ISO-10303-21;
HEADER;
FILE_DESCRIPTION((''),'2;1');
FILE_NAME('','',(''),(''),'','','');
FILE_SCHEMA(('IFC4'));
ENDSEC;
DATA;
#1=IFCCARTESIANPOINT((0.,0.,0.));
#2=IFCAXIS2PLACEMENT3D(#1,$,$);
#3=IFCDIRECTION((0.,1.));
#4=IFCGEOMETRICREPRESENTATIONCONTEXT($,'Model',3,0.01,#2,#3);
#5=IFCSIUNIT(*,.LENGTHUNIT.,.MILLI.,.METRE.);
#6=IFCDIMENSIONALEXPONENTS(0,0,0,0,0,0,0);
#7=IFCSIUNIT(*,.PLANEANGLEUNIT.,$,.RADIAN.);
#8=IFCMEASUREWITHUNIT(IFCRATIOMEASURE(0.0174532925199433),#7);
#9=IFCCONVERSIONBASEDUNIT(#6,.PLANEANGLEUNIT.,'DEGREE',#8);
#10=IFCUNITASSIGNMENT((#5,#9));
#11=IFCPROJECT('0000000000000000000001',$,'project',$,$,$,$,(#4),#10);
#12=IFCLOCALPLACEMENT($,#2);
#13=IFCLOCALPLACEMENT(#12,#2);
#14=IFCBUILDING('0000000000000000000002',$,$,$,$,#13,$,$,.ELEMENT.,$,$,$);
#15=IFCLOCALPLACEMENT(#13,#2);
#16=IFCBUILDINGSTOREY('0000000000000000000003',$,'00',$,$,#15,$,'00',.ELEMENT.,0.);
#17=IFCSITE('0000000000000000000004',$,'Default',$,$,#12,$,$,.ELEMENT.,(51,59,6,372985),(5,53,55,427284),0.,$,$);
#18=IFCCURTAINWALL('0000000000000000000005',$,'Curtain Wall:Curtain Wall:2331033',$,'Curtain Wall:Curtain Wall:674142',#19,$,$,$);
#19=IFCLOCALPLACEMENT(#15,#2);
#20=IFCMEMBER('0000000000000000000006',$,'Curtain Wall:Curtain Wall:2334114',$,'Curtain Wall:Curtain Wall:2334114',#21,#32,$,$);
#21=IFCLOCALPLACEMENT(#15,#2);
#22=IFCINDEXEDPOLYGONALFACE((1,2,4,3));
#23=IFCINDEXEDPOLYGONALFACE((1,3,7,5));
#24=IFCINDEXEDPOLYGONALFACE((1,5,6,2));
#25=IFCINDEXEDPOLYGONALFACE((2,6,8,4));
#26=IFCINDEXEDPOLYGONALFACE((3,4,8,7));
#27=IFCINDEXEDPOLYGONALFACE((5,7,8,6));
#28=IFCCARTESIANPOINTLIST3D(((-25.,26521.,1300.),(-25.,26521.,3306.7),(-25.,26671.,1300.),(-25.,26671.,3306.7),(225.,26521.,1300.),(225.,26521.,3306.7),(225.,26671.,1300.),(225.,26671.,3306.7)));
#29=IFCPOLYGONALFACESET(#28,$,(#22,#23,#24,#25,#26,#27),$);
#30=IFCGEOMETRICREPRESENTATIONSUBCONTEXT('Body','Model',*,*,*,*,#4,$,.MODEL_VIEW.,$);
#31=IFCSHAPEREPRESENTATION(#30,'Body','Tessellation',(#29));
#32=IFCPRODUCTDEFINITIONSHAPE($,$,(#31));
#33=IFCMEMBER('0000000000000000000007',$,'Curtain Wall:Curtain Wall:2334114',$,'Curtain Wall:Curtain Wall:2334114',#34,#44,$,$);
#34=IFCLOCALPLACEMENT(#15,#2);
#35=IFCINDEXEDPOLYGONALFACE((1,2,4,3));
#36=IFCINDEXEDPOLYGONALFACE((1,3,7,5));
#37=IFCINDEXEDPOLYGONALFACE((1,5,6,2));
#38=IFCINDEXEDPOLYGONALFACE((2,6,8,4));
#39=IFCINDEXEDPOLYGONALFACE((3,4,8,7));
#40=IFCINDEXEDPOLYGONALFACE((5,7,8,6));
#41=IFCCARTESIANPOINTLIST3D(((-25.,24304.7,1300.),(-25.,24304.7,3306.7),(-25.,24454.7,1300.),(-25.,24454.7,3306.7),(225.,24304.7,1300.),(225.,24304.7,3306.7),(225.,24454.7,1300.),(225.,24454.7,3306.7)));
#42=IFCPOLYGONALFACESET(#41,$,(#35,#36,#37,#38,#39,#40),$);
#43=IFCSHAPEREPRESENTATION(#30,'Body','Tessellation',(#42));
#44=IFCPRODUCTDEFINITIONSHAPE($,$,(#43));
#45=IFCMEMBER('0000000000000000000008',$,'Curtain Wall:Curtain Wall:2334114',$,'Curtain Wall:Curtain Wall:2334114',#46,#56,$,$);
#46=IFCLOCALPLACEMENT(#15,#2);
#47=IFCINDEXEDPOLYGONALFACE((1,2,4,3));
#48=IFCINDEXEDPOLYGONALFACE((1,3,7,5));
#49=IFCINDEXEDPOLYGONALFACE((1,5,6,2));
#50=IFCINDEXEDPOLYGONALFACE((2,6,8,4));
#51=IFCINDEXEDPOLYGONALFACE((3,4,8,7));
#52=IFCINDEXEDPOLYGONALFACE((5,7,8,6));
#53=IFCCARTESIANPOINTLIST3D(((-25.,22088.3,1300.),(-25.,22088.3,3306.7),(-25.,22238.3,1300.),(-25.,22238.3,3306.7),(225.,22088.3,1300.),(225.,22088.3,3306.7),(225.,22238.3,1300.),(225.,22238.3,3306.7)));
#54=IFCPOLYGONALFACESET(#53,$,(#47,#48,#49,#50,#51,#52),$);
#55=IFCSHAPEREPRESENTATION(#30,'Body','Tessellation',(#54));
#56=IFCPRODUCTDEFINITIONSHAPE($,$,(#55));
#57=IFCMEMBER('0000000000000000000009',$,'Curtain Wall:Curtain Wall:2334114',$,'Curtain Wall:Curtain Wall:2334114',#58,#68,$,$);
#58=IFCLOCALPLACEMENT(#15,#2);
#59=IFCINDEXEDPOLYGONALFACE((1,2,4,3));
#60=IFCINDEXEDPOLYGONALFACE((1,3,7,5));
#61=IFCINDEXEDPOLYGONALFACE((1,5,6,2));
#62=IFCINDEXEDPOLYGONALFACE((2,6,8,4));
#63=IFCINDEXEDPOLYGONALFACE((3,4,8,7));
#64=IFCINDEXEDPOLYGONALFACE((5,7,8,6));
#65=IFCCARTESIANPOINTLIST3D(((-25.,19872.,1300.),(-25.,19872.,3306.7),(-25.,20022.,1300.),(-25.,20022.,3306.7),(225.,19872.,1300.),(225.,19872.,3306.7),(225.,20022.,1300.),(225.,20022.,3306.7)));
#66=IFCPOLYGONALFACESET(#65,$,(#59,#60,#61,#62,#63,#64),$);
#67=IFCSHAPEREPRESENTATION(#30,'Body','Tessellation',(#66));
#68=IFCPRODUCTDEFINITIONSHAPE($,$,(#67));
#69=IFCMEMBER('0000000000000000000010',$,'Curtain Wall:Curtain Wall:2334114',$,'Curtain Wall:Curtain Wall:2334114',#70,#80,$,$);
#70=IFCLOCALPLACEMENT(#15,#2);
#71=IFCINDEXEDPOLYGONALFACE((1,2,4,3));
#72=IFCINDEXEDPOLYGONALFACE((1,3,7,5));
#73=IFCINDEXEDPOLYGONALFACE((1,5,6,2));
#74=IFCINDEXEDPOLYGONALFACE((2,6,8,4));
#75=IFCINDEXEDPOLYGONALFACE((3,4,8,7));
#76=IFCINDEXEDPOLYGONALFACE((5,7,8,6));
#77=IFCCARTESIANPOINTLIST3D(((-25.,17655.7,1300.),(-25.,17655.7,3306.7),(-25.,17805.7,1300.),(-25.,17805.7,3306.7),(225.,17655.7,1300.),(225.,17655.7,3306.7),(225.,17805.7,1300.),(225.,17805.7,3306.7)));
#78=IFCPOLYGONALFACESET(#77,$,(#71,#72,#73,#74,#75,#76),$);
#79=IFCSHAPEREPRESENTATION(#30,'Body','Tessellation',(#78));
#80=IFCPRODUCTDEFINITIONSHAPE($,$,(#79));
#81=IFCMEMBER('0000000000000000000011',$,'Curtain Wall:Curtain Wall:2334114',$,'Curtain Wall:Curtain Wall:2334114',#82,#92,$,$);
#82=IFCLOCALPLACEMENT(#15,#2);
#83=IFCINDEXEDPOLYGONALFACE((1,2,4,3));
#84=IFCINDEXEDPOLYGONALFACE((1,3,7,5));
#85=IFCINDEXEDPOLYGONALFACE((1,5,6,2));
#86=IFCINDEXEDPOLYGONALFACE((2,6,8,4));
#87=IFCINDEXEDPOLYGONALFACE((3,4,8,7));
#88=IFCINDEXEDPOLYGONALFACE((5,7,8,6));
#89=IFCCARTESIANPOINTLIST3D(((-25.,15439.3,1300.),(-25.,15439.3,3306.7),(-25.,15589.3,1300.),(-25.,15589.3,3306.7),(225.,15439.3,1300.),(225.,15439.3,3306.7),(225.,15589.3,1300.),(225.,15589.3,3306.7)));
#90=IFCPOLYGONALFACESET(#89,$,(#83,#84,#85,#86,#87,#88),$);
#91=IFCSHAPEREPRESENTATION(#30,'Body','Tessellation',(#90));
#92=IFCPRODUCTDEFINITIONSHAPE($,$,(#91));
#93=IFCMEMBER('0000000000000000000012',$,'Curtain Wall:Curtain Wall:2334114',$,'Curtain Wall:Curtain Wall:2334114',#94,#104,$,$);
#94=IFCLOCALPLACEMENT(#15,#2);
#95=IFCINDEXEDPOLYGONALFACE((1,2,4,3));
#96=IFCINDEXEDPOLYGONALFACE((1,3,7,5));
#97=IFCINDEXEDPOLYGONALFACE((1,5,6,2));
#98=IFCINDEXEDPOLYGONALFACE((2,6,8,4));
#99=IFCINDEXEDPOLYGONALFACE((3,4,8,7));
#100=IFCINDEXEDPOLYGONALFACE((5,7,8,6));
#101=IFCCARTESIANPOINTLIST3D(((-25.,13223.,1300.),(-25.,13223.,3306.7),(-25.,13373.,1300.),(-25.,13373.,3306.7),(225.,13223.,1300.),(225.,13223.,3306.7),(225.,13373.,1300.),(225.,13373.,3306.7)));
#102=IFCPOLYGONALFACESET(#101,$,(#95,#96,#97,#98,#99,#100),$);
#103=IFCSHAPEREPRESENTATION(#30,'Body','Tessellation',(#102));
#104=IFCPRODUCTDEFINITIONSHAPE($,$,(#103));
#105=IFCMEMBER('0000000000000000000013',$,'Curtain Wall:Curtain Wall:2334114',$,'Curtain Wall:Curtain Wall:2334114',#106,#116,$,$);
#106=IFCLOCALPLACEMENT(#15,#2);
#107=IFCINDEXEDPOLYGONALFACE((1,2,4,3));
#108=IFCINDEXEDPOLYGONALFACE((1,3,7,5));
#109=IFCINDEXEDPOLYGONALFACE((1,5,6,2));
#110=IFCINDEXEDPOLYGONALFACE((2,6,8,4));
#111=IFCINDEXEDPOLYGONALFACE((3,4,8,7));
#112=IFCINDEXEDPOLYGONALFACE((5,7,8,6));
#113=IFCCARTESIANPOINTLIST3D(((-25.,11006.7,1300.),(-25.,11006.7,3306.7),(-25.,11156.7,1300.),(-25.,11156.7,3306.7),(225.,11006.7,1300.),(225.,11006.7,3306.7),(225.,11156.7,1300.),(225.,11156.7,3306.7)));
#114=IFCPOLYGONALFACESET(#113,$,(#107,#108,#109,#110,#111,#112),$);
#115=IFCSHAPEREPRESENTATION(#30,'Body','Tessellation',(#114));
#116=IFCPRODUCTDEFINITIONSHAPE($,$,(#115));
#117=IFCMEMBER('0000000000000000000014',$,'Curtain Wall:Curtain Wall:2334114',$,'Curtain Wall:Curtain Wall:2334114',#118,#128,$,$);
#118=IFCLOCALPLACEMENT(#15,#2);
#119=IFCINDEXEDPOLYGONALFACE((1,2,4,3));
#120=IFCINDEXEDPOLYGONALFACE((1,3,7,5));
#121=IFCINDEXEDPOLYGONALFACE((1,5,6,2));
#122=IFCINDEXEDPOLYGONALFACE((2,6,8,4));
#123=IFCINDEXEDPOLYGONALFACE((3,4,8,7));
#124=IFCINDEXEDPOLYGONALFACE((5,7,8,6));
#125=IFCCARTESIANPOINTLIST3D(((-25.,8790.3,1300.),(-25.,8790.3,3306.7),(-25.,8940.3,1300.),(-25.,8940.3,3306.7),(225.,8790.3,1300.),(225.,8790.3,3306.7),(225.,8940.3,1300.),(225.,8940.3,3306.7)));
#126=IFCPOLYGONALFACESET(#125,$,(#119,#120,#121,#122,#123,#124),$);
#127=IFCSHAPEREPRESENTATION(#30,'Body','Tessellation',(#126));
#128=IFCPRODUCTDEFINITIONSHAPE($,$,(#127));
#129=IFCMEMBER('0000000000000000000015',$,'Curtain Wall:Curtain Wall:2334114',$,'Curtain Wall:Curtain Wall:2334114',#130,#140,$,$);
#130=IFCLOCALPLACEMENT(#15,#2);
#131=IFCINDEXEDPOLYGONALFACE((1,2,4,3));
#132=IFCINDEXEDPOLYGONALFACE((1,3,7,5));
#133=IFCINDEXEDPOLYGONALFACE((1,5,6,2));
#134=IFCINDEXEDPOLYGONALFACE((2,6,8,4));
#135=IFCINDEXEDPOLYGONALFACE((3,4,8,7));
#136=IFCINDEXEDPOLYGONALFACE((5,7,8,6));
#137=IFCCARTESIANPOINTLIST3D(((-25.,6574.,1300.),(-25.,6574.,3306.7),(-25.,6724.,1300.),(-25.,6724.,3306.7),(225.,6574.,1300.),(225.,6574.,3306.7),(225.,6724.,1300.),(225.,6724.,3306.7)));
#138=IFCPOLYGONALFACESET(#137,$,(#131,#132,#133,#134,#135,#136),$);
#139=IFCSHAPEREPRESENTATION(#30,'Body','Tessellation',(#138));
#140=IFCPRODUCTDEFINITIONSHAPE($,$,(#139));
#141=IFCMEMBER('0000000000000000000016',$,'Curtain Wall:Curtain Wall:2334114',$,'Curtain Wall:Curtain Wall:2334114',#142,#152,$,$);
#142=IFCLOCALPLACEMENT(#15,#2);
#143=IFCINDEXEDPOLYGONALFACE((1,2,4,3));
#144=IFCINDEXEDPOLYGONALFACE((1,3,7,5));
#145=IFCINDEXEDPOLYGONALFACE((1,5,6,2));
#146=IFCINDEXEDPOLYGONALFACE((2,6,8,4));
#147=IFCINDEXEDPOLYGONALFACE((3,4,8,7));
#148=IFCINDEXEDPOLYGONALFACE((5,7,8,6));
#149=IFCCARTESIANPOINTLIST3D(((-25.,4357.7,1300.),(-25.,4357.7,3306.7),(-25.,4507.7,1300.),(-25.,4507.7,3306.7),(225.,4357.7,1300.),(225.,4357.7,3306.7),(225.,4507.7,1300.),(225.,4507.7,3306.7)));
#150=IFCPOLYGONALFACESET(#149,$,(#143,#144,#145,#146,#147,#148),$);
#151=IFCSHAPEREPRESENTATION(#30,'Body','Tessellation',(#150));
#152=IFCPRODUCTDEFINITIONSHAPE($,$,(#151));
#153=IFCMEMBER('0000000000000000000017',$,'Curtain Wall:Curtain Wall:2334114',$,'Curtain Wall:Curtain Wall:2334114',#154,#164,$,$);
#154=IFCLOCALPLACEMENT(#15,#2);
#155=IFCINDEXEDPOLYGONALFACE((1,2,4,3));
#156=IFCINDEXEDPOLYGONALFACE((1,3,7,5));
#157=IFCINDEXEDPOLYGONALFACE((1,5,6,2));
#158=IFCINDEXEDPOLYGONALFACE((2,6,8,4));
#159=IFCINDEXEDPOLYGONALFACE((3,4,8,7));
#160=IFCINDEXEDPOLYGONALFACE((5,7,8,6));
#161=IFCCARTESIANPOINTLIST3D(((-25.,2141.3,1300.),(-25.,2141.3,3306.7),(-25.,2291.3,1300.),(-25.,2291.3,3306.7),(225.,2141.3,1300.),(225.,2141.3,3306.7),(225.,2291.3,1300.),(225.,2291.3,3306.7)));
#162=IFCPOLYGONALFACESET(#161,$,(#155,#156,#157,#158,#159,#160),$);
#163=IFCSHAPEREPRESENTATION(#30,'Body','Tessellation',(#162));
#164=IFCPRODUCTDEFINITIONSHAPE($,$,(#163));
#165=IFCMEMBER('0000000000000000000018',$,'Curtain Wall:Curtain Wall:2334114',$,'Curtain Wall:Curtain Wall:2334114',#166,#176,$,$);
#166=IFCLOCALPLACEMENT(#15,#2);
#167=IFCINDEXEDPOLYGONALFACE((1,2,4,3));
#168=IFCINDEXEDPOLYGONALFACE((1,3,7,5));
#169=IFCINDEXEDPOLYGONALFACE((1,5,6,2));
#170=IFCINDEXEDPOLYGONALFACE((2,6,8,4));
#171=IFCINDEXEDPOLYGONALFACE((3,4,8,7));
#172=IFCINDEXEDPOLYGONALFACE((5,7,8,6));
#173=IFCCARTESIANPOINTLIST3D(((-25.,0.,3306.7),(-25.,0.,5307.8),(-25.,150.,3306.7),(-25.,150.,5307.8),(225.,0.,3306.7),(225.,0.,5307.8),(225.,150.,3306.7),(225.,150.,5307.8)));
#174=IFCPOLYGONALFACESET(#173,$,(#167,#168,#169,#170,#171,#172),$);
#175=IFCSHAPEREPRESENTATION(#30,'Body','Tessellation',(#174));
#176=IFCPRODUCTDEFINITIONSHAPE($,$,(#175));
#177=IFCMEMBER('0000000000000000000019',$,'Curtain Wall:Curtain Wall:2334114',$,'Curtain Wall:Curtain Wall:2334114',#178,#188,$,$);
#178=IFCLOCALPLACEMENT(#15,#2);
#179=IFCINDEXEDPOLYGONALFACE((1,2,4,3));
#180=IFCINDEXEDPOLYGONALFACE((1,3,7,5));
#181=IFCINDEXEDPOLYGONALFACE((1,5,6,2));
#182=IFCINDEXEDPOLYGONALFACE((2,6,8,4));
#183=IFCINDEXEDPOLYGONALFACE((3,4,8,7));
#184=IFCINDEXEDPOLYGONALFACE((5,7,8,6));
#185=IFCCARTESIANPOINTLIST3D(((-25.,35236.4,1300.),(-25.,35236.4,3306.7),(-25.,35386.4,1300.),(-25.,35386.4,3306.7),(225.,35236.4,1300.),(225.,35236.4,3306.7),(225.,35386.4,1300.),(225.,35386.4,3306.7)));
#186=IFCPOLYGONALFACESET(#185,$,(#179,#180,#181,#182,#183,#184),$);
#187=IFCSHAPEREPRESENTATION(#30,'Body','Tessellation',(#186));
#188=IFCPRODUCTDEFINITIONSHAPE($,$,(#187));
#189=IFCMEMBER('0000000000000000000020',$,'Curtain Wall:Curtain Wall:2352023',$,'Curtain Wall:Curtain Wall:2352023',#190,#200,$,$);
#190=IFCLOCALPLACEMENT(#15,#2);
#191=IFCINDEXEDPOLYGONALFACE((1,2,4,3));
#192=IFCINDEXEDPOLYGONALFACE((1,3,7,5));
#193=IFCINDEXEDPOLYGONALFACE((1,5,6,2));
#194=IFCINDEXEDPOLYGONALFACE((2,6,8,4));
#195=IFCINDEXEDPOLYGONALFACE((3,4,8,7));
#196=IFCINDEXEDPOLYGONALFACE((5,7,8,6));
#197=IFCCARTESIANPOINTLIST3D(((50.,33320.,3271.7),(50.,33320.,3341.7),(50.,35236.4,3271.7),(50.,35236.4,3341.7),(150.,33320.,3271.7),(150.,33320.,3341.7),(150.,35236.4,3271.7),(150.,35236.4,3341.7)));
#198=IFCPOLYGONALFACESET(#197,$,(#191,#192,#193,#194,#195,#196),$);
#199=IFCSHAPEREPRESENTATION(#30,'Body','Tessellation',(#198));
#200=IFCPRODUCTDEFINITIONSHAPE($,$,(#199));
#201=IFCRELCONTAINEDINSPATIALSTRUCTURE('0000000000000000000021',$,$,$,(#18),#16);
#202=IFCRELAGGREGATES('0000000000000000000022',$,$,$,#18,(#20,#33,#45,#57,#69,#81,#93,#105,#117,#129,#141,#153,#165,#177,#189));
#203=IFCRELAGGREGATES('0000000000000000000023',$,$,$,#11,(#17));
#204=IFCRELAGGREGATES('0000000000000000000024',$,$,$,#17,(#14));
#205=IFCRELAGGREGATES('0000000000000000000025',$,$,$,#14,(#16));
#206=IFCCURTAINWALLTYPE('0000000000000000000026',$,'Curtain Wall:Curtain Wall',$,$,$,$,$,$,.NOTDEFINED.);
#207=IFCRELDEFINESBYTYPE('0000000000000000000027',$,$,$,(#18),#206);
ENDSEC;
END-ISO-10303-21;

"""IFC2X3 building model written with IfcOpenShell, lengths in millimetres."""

from ifc_helpers import new_model, entity, si_unit, converted_unit, direction, frame, frame_2d, origin, origin_2d_with_axis, place, context, subcontext, project, spatial, rectangle, extrude, type_object, element, aggregate, save


model = new_model("IFC2X3")

# Units and contexts
model_context = context("Model", 3, precision=0.01, world=origin(), true_north=direction((0.0, 1.0)))
body_context = subcontext(model_context, "Body", "Model", "MODEL_VIEW")
ifc_project = project(units=[si_unit("LENGTHUNIT", "METRE", prefix="MILLI"), converted_unit("PLANEANGLEUNIT", "DEGREE", entity("IfcRatioMeasure", 0.0174532925199433), si_unit("PLANEANGLEUNIT", "RADIAN"), dimensions=[0, 0, 0, 0, 0, 0, 0])], contexts=[model_context])

# Site, building, storey
site_placement = place(None, origin())
site = spatial("IfcSite", under=ifc_project, at=site_placement, Name="Default", CompositionType="ELEMENT", RefLatitude=(51, 59, 6, 372985), RefLongitude=(5, 53, 55, 427284), RefElevation=0.0)
building_placement = place(site_placement, origin())
building = spatial("IfcBuilding", under=site, at=building_placement, CompositionType="ELEMENT")
storey_placement = place(building_placement, origin())
storey = spatial("IfcBuildingStorey", under=building, at=storey_placement, Name="00", LongName="00", CompositionType="ELEMENT", Elevation=0.0)

# Curtain wall, members
curtain_wall_type = type_object("IfcCurtainWallType", Name="Curtain Wall:Curtain Wall", PredefinedType="NOTDEFINED")
curtain_wall_placement = place(storey_placement, origin())
curtain_wall = element("IfcCurtainWall", 1, at=curtain_wall_placement, inside=storey, type_object=curtain_wall_type, Name="Curtain Wall:Curtain Wall:2331033", ObjectType="Curtain Wall:Curtain Wall:674142")
member_1_placement = place(curtain_wall_placement, origin())
member_1 = element("IfcMember", 2, at=member_1_placement, Name="Curtain Wall:Curtain Wall:2334114", ObjectType="Curtain Wall:Curtain Wall:2334114", context=body_context, shape_type="SweptSolid", body=[
    extrude(rectangle(XDim=250.0, YDim=150.0, at=frame_2d((0.0, 0.0), x_axis=(1.0, 0.0))), frame((100.0, 26596.0, 1300.0), z_axis=(0.0, 0.0, 1.0), x_axis=(-1.0, 0.0, 0.0)), (0.0, 0.0, 1.0), 2006.7),
])
member_2_placement = place(curtain_wall_placement, origin())
member_2 = element("IfcMember", 3, at=member_2_placement, Name="Curtain Wall:Curtain Wall:2334114", ObjectType="Curtain Wall:Curtain Wall:2334114", context=body_context, shape_type="SweptSolid", body=[
    extrude(rectangle(XDim=250.0, YDim=150.0, at=origin_2d_with_axis()), frame((100.0, 24379.7, 1300.0), z_axis=(0.0, 0.0, 1.0), x_axis=(-1.0, 0.0, 0.0)), (0.0, 0.0, 1.0), 2006.7),
])
member_3_placement = place(curtain_wall_placement, origin())
member_3 = element("IfcMember", 4, at=member_3_placement, Name="Curtain Wall:Curtain Wall:2334114", ObjectType="Curtain Wall:Curtain Wall:2334114", context=body_context, shape_type="SweptSolid", body=[
    extrude(rectangle(XDim=250.0, YDim=150.0, at=origin_2d_with_axis()), frame((100.0, 22163.3, 1300.0), z_axis=(0.0, 0.0, 1.0), x_axis=(-1.0, 0.0, 0.0)), (0.0, 0.0, 1.0), 2006.7),
])
member_4_placement = place(curtain_wall_placement, origin())
member_4 = element("IfcMember", 5, at=member_4_placement, Name="Curtain Wall:Curtain Wall:2334114", ObjectType="Curtain Wall:Curtain Wall:2334114", context=body_context, shape_type="SweptSolid", body=[
    extrude(rectangle(XDim=250.0, YDim=150.0, at=frame_2d((0.0, 0.0), x_axis=(1.0, 0.0))), frame((100.0, 19947.0, 1300.0), z_axis=(0.0, 0.0, 1.0), x_axis=(-1.0, 0.0, 0.0)), (0.0, 0.0, 1.0), 2006.7),
])
member_5_placement = place(curtain_wall_placement, origin())
member_5 = element("IfcMember", 6, at=member_5_placement, Name="Curtain Wall:Curtain Wall:2334114", ObjectType="Curtain Wall:Curtain Wall:2334114", context=body_context, shape_type="SweptSolid", body=[
    extrude(rectangle(XDim=250.0, YDim=150.0, at=frame_2d((0.0, 0.0), x_axis=(1.0, 0.0))), frame((100.0, 17730.7, 1300.0), z_axis=(0.0, 0.0, 1.0), x_axis=(-1.0, 0.0, 0.0)), (0.0, 0.0, 1.0), 2006.7),
])
member_6_placement = place(curtain_wall_placement, origin())
member_6 = element("IfcMember", 7, at=member_6_placement, Name="Curtain Wall:Curtain Wall:2334114", ObjectType="Curtain Wall:Curtain Wall:2334114", context=body_context, shape_type="SweptSolid", body=[
    extrude(rectangle(XDim=250.0, YDim=150.0, at=frame_2d((0.0, 0.0), x_axis=(1.0, 0.0))), frame((100.0, 15514.3, 1300.0), z_axis=(0.0, 0.0, 1.0), x_axis=(-1.0, 0.0, 0.0)), (0.0, 0.0, 1.0), 2006.7),
])
member_7_placement = place(curtain_wall_placement, origin())
member_7 = element("IfcMember", 8, at=member_7_placement, Name="Curtain Wall:Curtain Wall:2334114", ObjectType="Curtain Wall:Curtain Wall:2334114", context=body_context, shape_type="SweptSolid", body=[
    extrude(rectangle(XDim=250.0, YDim=150.0, at=origin_2d_with_axis()), frame((100.0, 13298.0, 1300.0), z_axis=(0.0, 0.0, 1.0), x_axis=(-1.0, 0.0, 0.0)), (0.0, 0.0, 1.0), 2006.7),
])
member_8_placement = place(curtain_wall_placement, origin())
member_8 = element("IfcMember", 9, at=member_8_placement, Name="Curtain Wall:Curtain Wall:2334114", ObjectType="Curtain Wall:Curtain Wall:2334114", context=body_context, shape_type="SweptSolid", body=[
    extrude(rectangle(XDim=250.0, YDim=150.0, at=origin_2d_with_axis()), frame((100.0, 11081.7, 1300.0), z_axis=(0.0, 0.0, 1.0), x_axis=(-1.0, 0.0, 0.0)), (0.0, 0.0, 1.0), 2006.7),
])
member_9_placement = place(curtain_wall_placement, origin())
member_9 = element("IfcMember", 10, at=member_9_placement, Name="Curtain Wall:Curtain Wall:2334114", ObjectType="Curtain Wall:Curtain Wall:2334114", context=body_context, shape_type="SweptSolid", body=[
    extrude(rectangle(XDim=250.0, YDim=150.0, at=frame_2d((0.0, 0.0), x_axis=(1.0, 0.0))), frame((100.0, 8865.3, 1300.0), z_axis=(0.0, 0.0, 1.0), x_axis=(-1.0, 0.0, 0.0)), (0.0, 0.0, 1.0), 2006.7),
])
member_10_placement = place(curtain_wall_placement, origin())
member_10 = element("IfcMember", 11, at=member_10_placement, Name="Curtain Wall:Curtain Wall:2334114", ObjectType="Curtain Wall:Curtain Wall:2334114", context=body_context, shape_type="SweptSolid", body=[
    extrude(rectangle(XDim=250.0, YDim=150.0, at=frame_2d((0.0, 0.0), x_axis=(1.0, 0.0))), frame((100.0, 6649.0, 1300.0), z_axis=(0.0, 0.0, 1.0), x_axis=(-1.0, 0.0, 0.0)), (0.0, 0.0, 1.0), 2006.7),
])
member_11_placement = place(curtain_wall_placement, origin())
member_11 = element("IfcMember", 12, at=member_11_placement, Name="Curtain Wall:Curtain Wall:2334114", ObjectType="Curtain Wall:Curtain Wall:2334114", context=body_context, shape_type="SweptSolid", body=[
    extrude(rectangle(XDim=250.0, YDim=150.0, at=frame_2d((0.0, 0.0), x_axis=(1.0, 0.0))), frame((100.0, 4432.7, 1300.0), z_axis=(0.0, 0.0, 1.0), x_axis=(-1.0, 0.0, 0.0)), (0.0, 0.0, 1.0), 2006.7),
])
member_12_placement = place(curtain_wall_placement, origin())
member_12 = element("IfcMember", 13, at=member_12_placement, Name="Curtain Wall:Curtain Wall:2334114", ObjectType="Curtain Wall:Curtain Wall:2334114", context=body_context, shape_type="SweptSolid", body=[
    extrude(rectangle(XDim=250.0, YDim=150.0, at=frame_2d((0.0, 0.0), x_axis=(1.0, 0.0))), frame((100.0, 2216.3, 1300.0), z_axis=(0.0, 0.0, 1.0), x_axis=(-1.0, 0.0, 0.0)), (0.0, 0.0, 1.0), 2006.7),
])
member_13_placement = place(curtain_wall_placement, origin())
member_13 = element("IfcMember", 14, at=member_13_placement, Name="Curtain Wall:Curtain Wall:2334114", ObjectType="Curtain Wall:Curtain Wall:2334114", context=body_context, shape_type="SweptSolid", body=[
    extrude(rectangle(XDim=250.0, YDim=150.0, at=frame_2d((0.0, 0.0), x_axis=(1.0, 0.0))), frame((100.0, 75.0, 3306.7), z_axis=(0.0, 0.0, 1.0), x_axis=(-1.0, 0.0, 0.0)), (0.0, 0.0, 1.0), 2001.1),
])
member_14_placement = place(curtain_wall_placement, origin())
member_14 = element("IfcMember", 15, at=member_14_placement, Name="Curtain Wall:Curtain Wall:2334114", ObjectType="Curtain Wall:Curtain Wall:2334114", context=body_context, shape_type="SweptSolid", body=[
    extrude(rectangle(XDim=250.0, YDim=150.0, at=origin_2d_with_axis()), frame((100.0, 35311.4, 3306.7), z_axis=(0.0, 0.0, -1.0), x_axis=(-1.0, 0.0, 0.0)), (0.0, 0.0, 1.0), 2006.7),
])
member_15_placement = place(curtain_wall_placement, origin())
member_15 = element("IfcMember", 16, at=member_15_placement, Name="Curtain Wall:Curtain Wall:2352023", ObjectType="Curtain Wall:Curtain Wall:2352023", context=body_context, shape_type="SweptSolid", body=[
    extrude(rectangle(XDim=70.0, YDim=100.0, at=frame_2d((0.0, 0.0), x_axis=(1.0, 0.0))), frame((100.0, 33320.0, 3306.7), z_axis=(0.0, 1.0, 0.0), x_axis=(0.0, 0.0, -1.0)), (0.0, 0.0, 1.0), 1916.3),
])
aggregate(curtain_wall, [member_1, member_2, member_3, member_4, member_5, member_6, member_7, member_8, member_9, member_10, member_11, member_12, member_13, member_14, member_15])

save(model, "model.ifc")
